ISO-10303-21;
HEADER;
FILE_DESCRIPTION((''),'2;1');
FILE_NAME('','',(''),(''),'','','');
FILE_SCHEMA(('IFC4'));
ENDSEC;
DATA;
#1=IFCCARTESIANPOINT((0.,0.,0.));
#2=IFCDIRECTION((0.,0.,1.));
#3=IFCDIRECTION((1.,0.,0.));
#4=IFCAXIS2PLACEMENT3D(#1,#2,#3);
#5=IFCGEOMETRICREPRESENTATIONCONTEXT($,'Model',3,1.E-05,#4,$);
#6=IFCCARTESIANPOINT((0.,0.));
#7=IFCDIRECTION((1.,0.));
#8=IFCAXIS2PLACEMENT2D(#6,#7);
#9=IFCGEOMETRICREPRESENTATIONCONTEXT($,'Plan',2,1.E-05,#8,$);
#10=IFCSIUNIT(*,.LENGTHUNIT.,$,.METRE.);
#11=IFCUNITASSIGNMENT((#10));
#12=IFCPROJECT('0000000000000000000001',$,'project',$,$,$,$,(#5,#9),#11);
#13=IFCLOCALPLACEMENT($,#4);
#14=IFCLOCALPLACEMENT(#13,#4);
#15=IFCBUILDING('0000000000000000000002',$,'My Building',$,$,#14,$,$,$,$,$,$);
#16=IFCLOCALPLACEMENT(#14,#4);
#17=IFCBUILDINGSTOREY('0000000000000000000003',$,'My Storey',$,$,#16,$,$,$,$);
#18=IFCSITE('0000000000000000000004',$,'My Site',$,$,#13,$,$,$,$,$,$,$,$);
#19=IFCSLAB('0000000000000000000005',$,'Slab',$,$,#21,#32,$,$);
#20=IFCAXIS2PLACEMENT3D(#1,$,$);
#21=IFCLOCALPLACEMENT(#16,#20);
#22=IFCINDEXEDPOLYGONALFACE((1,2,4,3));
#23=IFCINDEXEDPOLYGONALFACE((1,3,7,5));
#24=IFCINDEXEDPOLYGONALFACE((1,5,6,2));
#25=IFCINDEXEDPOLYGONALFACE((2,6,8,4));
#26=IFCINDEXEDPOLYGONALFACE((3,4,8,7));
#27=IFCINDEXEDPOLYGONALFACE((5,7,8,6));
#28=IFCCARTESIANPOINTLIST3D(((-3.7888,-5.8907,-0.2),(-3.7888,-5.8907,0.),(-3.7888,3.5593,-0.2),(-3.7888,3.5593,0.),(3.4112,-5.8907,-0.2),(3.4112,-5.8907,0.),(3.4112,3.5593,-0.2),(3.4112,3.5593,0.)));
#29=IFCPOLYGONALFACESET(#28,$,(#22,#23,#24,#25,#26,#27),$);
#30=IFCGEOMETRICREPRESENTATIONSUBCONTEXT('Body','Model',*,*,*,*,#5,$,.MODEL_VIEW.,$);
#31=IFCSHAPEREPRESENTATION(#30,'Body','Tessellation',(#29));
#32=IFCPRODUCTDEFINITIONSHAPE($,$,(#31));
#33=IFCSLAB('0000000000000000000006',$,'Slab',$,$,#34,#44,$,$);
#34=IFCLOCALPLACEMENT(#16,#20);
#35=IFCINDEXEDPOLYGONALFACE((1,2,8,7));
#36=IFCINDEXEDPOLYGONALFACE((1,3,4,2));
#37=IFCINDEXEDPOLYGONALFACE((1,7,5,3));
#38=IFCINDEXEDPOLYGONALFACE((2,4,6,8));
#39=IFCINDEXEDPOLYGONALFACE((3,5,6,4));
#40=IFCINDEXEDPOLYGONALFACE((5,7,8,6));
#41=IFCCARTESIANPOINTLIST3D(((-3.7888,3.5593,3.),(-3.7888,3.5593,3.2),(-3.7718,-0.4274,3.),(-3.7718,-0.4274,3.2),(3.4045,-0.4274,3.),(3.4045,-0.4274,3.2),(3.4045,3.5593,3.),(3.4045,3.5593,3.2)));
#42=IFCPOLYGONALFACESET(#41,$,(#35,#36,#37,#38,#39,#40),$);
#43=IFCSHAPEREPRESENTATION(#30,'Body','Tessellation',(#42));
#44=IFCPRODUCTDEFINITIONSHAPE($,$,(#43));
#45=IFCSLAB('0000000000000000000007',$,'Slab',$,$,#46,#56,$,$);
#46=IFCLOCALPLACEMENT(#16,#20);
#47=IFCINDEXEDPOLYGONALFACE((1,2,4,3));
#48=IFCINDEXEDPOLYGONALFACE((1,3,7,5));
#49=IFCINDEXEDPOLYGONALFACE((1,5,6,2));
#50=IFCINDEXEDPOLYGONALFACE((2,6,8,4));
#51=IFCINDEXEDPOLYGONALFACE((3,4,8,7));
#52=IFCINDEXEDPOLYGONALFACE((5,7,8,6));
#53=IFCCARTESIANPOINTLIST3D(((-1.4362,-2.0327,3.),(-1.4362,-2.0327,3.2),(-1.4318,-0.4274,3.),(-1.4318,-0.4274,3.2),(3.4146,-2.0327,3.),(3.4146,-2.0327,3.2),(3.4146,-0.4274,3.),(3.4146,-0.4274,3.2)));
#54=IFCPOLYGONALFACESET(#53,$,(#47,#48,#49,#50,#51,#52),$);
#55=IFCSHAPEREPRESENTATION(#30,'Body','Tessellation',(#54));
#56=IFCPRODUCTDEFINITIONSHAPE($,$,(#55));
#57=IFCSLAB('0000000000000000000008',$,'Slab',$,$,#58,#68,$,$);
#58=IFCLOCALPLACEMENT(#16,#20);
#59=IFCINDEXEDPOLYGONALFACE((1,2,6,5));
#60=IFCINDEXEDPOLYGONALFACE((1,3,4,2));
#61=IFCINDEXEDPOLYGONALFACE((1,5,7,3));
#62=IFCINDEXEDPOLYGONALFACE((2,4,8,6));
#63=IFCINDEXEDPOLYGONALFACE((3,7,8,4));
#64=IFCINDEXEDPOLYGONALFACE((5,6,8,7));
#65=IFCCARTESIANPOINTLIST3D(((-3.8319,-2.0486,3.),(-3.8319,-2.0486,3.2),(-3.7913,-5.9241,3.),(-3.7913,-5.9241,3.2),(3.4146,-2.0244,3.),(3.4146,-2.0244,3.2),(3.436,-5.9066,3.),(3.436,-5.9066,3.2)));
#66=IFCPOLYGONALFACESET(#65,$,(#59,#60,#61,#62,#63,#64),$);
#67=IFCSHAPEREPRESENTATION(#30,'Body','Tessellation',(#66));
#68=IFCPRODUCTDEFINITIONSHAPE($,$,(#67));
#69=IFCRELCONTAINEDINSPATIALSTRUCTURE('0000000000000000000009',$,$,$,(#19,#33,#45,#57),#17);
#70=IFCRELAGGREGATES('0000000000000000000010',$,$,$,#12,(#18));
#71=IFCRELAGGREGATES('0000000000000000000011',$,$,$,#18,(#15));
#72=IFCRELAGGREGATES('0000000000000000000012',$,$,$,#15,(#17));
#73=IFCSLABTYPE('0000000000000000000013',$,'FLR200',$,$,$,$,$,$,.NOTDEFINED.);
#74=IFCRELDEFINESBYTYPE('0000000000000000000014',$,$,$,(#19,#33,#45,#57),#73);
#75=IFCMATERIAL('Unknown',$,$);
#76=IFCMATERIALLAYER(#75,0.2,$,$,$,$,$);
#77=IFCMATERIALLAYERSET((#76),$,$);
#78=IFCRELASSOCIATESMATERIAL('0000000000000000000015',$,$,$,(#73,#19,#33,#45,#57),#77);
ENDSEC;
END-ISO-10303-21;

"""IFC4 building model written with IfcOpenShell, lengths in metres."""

from ifc_helpers import new_model, si_unit, frame, origin_with_axes, origin_2d_with_axis, place, context, subcontext, project, spatial, indexed_curve, outline, extrude, material, layer, layer_set, layer_usage, type_object, element, save


model = new_model("IFC4")

# Units and contexts
model_context = context("Model", 3, precision=1e-05, world=origin_with_axes())
plan_context = context("Plan", 2, precision=1e-05, world=origin_2d_with_axis())
body_context_1 = subcontext(model_context, "Body", "Model", "MODEL_VIEW")
ifc_project = project(units=[si_unit("LENGTHUNIT", "METRE")], contexts=[model_context, plan_context])

# Site, building, storey
site_placement = place(None, origin_with_axes())
site = spatial("IfcSite", under=ifc_project, at=site_placement, Name="My Site")
building_placement = place(site_placement, origin_with_axes())
building = spatial("IfcBuilding", under=site, at=building_placement, Name="My Building")
storey_placement = place(building_placement, origin_with_axes())
storey = spatial("IfcBuildingStorey", under=building, at=storey_placement, Name="My Storey")

# Slabs
ifc_material = material(Name="Unknown")
ifc_layer_1 = layer(ifc_material, 0.2)
ifc_layer_set_1 = layer_set([ifc_layer_1])
ifc_layer_usage_1 = layer_usage(ifc_layer_set_1, "AXIS3", "POSITIVE", -0.2)
slab_type = type_object("IfcSlabType", Name="FLR200", PredefinedType="NOTDEFINED", material=ifc_layer_set_1)
slab_1_placement = place(storey_placement, frame((-3.7888, 3.5593, 0.0), z_axis=(0.0, 0.0, 1.0), x_axis=(1.0, 0.0, 0.0)))
element("IfcSlab", 1, at=slab_1_placement, inside=storey, type_object=slab_type, material=ifc_layer_usage_1, Name="Slab", context=body_context_1, shape_type="SweptSolid", body=[
    extrude(outline(indexed_curve([(0.0, 0.0), (7.2, 0.0), (7.2, -9.45), (0.0, -9.45), (0.0, 0.0)])), frame((0.0, 0.0, -0.2), z_axis=(0.0, 0.0, 1.0), x_axis=(1.0, 0.0, 0.0)), (0.0, 0.0, 1.0), 0.2),
])
ifc_layer_usage_2 = layer_usage(ifc_layer_set_1, "AXIS3", "POSITIVE", -0.2)
slab_2_placement = place(storey_placement, frame((-3.7888, 3.5593, 3.2), z_axis=(0.0, 0.0, 1.0), x_axis=(1.0, 0.0, 0.0)))
element("IfcSlab", 2, at=slab_2_placement, inside=storey, type_object=slab_type, material=ifc_layer_usage_2, Name="Slab", context=body_context_1, shape_type="SweptSolid", body=[
    extrude(outline(indexed_curve([(0.0, 0.0), (0.0171, -3.9867), (7.1933, -3.9867), (7.1933, 0.0), (0.0, 0.0)])), frame((0.0, 0.0, -0.2), z_axis=(0.0, 0.0, 1.0), x_axis=(1.0, 0.0, 0.0)), (0.0, 0.0, 1.0), 0.2),
])
ifc_layer_usage_3 = layer_usage(ifc_layer_set_1, "AXIS3", "POSITIVE", -0.2)
slab_3_placement = place(storey_placement, frame((-1.4318, -0.4274, 3.2), z_axis=(0.0, 0.0, 1.0), x_axis=(1.0, 0.0, 0.0)))
element("IfcSlab", 3, at=slab_3_placement, inside=storey, type_object=slab_type, material=ifc_layer_usage_3, Name="Slab", context=body_context_1, shape_type="SweptSolid", body=[
    extrude(outline(indexed_curve([(0.0, 0.0), (-0.0044, -1.6054), (4.8464, -1.6054), (4.8464, 0.0), (0.0, 0.0)])), frame((0.0, 0.0, -0.2), z_axis=(0.0, 0.0, 1.0), x_axis=(1.0, 0.0, 0.0)), (0.0, 0.0, 1.0), 0.2),
])
ifc_layer_usage_4 = layer_usage(ifc_layer_set_1, "AXIS3", "POSITIVE", -0.2)
slab_4_placement = place(storey_placement, frame((-3.8319, -2.0486, 3.2), z_axis=(0.0, 0.0, 1.0), x_axis=(1.0, 0.0, 0.0)))
element("IfcSlab", 4, at=slab_4_placement, inside=storey, type_object=slab_type, material=ifc_layer_usage_4, Name="Slab", context=body_context_1, shape_type="SweptSolid", body=[
    extrude(outline(indexed_curve([(0.0, 0.0), (7.2465, 0.0242), (7.2679, -3.8579), (0.0406, -3.8755), (0.0, 0.0)])), frame((0.0, 0.0, -0.2), z_axis=(0.0, 0.0, 1.0), x_axis=(1.0, 0.0, 0.0)), (0.0, 0.0, 1.0), 0.2),
])

save(model, "model.ifc")
